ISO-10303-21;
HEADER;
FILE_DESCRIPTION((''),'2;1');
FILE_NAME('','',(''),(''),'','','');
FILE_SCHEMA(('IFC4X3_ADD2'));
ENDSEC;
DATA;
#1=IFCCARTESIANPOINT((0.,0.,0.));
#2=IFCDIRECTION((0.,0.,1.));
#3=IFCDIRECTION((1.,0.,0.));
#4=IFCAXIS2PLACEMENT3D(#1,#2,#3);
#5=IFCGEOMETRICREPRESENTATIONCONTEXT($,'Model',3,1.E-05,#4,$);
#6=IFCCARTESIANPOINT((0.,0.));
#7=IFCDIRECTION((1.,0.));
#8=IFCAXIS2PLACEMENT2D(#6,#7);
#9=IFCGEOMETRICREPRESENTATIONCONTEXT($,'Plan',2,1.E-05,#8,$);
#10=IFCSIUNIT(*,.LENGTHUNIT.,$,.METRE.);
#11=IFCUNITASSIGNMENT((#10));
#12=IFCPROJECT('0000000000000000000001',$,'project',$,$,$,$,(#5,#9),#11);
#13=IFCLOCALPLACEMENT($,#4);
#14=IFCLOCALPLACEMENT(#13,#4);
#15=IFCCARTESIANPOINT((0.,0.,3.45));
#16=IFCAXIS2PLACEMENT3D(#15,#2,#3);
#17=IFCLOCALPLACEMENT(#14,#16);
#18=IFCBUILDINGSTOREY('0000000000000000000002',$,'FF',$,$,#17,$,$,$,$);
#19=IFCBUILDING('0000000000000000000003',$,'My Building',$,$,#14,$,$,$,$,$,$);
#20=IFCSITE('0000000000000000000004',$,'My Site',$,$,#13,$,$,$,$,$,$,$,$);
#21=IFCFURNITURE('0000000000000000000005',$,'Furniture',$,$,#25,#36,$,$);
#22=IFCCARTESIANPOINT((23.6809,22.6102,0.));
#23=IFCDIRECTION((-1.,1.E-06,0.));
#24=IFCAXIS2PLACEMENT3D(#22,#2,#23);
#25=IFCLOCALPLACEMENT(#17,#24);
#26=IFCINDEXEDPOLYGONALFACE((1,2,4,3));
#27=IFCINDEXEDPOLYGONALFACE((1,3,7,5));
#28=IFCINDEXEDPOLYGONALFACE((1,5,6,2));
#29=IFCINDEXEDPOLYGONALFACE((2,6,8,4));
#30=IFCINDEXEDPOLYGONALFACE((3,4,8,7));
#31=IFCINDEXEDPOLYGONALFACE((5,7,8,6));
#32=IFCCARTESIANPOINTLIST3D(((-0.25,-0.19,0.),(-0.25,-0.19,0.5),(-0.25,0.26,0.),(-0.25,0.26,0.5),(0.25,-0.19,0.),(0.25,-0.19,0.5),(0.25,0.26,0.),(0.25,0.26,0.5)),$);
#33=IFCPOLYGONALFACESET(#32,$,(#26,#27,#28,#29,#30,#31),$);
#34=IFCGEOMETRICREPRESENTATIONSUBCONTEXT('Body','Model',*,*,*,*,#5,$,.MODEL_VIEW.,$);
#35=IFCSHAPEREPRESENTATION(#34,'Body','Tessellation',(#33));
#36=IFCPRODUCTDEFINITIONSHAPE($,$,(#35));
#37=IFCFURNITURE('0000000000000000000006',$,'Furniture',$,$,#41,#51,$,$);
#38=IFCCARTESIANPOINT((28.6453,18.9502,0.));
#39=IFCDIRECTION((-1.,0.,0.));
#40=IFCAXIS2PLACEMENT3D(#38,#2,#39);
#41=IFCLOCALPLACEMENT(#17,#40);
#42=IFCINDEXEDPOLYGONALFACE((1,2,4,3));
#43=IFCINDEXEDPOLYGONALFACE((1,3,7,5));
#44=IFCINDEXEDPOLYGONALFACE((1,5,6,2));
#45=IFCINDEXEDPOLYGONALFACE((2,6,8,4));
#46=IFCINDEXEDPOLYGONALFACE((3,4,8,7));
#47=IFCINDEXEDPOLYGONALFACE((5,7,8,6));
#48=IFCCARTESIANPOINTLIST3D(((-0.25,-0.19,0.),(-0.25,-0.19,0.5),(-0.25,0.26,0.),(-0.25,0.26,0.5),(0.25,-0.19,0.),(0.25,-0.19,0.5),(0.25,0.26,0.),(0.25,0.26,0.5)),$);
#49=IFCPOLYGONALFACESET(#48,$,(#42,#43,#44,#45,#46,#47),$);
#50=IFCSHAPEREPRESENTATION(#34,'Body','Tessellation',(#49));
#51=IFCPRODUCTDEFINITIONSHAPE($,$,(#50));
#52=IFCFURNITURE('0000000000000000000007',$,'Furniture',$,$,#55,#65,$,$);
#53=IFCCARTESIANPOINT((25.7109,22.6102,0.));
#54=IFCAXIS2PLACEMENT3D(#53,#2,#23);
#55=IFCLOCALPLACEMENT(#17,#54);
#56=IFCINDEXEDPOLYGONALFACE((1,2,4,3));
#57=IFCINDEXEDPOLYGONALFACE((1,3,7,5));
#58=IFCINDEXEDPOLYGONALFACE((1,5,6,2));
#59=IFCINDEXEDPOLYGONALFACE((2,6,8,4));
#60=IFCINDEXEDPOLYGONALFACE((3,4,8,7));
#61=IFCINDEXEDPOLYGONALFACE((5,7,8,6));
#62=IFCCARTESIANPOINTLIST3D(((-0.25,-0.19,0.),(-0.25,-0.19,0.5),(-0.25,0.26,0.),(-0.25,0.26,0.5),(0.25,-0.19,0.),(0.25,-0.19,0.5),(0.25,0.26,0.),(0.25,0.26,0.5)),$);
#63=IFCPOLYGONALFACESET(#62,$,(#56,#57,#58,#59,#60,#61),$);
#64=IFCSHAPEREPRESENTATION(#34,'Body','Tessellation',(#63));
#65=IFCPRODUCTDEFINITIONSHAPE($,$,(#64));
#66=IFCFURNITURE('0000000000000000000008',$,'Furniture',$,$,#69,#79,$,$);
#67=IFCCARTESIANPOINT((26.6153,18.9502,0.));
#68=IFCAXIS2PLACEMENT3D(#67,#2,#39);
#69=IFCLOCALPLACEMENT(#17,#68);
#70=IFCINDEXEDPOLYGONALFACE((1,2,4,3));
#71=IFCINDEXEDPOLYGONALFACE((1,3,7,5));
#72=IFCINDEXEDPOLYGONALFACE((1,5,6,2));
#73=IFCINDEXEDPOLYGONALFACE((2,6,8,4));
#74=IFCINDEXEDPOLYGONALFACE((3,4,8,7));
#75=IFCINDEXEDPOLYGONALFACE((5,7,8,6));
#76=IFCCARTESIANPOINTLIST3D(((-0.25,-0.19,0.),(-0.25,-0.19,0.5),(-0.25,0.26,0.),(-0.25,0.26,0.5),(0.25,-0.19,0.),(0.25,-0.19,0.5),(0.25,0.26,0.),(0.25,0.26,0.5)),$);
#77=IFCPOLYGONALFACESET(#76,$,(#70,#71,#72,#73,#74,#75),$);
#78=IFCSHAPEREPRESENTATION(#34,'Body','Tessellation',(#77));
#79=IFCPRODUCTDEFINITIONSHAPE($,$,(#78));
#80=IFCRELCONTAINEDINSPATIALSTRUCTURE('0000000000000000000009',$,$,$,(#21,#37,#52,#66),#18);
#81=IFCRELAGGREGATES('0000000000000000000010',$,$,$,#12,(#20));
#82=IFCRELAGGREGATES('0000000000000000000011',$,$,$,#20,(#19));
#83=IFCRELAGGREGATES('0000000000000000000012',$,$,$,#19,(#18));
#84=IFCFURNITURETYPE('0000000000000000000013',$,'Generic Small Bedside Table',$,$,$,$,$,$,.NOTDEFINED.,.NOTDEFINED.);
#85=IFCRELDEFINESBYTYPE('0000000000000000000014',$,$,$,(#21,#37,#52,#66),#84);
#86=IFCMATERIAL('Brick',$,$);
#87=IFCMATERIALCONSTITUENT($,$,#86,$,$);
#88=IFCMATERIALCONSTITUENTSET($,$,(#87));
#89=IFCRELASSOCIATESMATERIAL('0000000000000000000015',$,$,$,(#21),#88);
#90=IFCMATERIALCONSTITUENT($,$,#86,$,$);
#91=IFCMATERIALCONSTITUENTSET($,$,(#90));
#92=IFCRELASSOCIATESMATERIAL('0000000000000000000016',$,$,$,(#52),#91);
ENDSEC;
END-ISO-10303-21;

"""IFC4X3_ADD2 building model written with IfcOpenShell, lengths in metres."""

from ifc_helpers import new_model, entity, si_unit, frame, origin_with_axes, origin_2d_with_axis, place, context, subcontext, project, spatial, line, indexed_curve, outline, extrude, shape, source, transform, mapped, material, constituent, constituent_set, type_object, type_shapes, element, save


model = new_model("IFC4X3_ADD2")

# Units and contexts
model_context = context("Model", 3, precision=1e-05, world=origin_with_axes())
plan_context = context("Plan", 2, precision=1e-05, world=origin_2d_with_axis())
body_context_1 = subcontext(model_context, "Body", "Model", "MODEL_VIEW")
body_context_2 = subcontext(plan_context, "Body", "Plan", "PLAN_VIEW")
ifc_project = project(units=[si_unit("LENGTHUNIT", "METRE")], contexts=[model_context, plan_context])

# Site, building, storey
site_placement = place(None, origin_with_axes())
site = spatial("IfcSite", under=ifc_project, at=site_placement, Name="My Site")
building_placement = place(site_placement, origin_with_axes())
building = spatial("IfcBuilding", under=site, at=building_placement, Name="My Building")
storey_placement = place(building_placement, frame((0.0, 0.0, 3.45), z_axis=(0.0, 0.0, 1.0), x_axis=(1.0, 0.0, 0.0)))
storey = spatial("IfcBuildingStorey", under=building, at=storey_placement, Name="FF")

# Shared definitions
ifc_material_1 = material(Name="Brick")

# Furniture
ifc_constituent_1 = constituent(ifc_material_1)
ifc_constituent_set_1 = constituent_set(constituents=[ifc_constituent_1])
furniture_type_1 = type_object("IfcFurnitureType", Name="Generic Small Bedside Table", AssemblyPlace="NOTDEFINED", PredefinedType="NOTDEFINED")
shared_shape_1 = source(origin_with_axes(), body_context_1, "Body", "SweptSolid", [
    extrude(outline(indexed_curve([(0.5, 0.45), (0.5, 0.0), (0.0, 0.0), (0.0, 0.45)], segments=[line(4, 1), line(1, 2), line(2, 3), line(3, 4)], self_intersect=False)), frame((-0.25, -0.19, 0.0), z_axis=(0.0, 0.0, 1.0), x_axis=(1.0, 0.0, 0.0)), (0.0, 0.0, 1.0), 0.5),
])
shared_shape_2 = source(origin_with_axes(), body_context_2, "Body", "Annotation2D", [
    entity("IfcGeometricCurveSet", [entity("IfcIndexedPolyCurve", entity("IfcCartesianPointList2D", [[-0.25, -0.19], [0.25, -0.19], [0.25, 0.26], [-0.25, 0.26]]), [entity("IfcLineIndex", [1, 2]), entity("IfcLineIndex", [2, 3]), entity("IfcLineIndex", [3, 4]), entity("IfcLineIndex", [4, 1])])]),
])
type_shapes(furniture_type_1, [shared_shape_1, shared_shape_2])
furniture_1_placement = place(storey_placement, frame((23.6809, 22.6102, 0.0), z_axis=(0.0, 0.0, 1.0), x_axis=(-1.0, 0.000001, 0.0)))
element("IfcFurniture", 1, at=furniture_1_placement, inside=storey, type_object=furniture_type_1, material=ifc_constituent_set_1, Name="Furniture", shapes=[
    shape(body_context_1, "Body", "MappedRepresentation", [mapped(shared_shape_1, transform((0.0, 0.0, 0.0), x_axis=(1.0, 0.0, 0.0), y_axis=(0.0, 1.0, 0.0), z_axis=(0.0, 0.0, 1.0), scale=1.0))]),
    shape(body_context_2, "Body", "MappedRepresentation", [mapped(shared_shape_2, transform((0.0, 0.0, 0.0), x_axis=(1.0, 0.0, 0.0), y_axis=(0.0, 1.0, 0.0), z_axis=(0.0, 0.0, 1.0), scale=1.0))]),
])
furniture_2_placement = place(storey_placement, frame((28.6453, 18.9502, 0.0), z_axis=(0.0, 0.0, 1.0), x_axis=(-1.0, 0.0, 0.0)))
element("IfcFurniture", 2, at=furniture_2_placement, inside=storey, type_object=furniture_type_1, Name="Furniture", shapes=[
    shape(body_context_1, "Body", "MappedRepresentation", [mapped(shared_shape_1, transform((0.0, 0.0, 0.0), x_axis=(1.0, 0.0, 0.0), y_axis=(0.0, 1.0, 0.0), z_axis=(0.0, 0.0, 1.0), scale=1.0))]),
    shape(body_context_2, "Body", "MappedRepresentation", [mapped(shared_shape_2, transform((0.0, 0.0, 0.0), x_axis=(1.0, 0.0, 0.0), y_axis=(0.0, 1.0, 0.0), z_axis=(0.0, 0.0, 1.0), scale=1.0))]),
])
ifc_constituent_2 = constituent(ifc_material_1)
ifc_constituent_set_2 = constituent_set(constituents=[ifc_constituent_2])
furniture_3_placement = place(storey_placement, frame((25.7109, 22.6102, 0.0), z_axis=(0.0, 0.0, 1.0), x_axis=(-1.0, 0.000001, 0.0)))
element("IfcFurniture", 3, at=furniture_3_placement, inside=storey, type_object=furniture_type_1, material=ifc_constituent_set_2, Name="Furniture", shapes=[
    shape(body_context_1, "Body", "MappedRepresentation", [mapped(shared_shape_1, transform((0.0, 0.0, 0.0), x_axis=(1.0, 0.0, 0.0), y_axis=(0.0, 1.0, 0.0), z_axis=(0.0, 0.0, 1.0), scale=1.0))]),
    shape(body_context_2, "Body", "MappedRepresentation", [mapped(shared_shape_2, transform((0.0, 0.0, 0.0), x_axis=(1.0, 0.0, 0.0), y_axis=(0.0, 1.0, 0.0), z_axis=(0.0, 0.0, 1.0), scale=1.0))]),
])
furniture_4_placement = place(storey_placement, frame((26.6153, 18.9502, 0.0), z_axis=(0.0, 0.0, 1.0), x_axis=(-1.0, 0.0, 0.0)))
element("IfcFurniture", 4, at=furniture_4_placement, inside=storey, type_object=furniture_type_1, Name="Furniture", shapes=[
    shape(body_context_1, "Body", "MappedRepresentation", [mapped(shared_shape_1, transform((0.0, 0.0, 0.0), x_axis=(1.0, 0.0, 0.0), y_axis=(0.0, 1.0, 0.0), z_axis=(0.0, 0.0, 1.0), scale=1.0))]),
    shape(body_context_2, "Body", "MappedRepresentation", [mapped(shared_shape_2, transform((0.0, 0.0, 0.0), x_axis=(1.0, 0.0, 0.0), y_axis=(0.0, 1.0, 0.0), z_axis=(0.0, 0.0, 1.0), scale=1.0))]),
])

save(model, "model.ifc")
